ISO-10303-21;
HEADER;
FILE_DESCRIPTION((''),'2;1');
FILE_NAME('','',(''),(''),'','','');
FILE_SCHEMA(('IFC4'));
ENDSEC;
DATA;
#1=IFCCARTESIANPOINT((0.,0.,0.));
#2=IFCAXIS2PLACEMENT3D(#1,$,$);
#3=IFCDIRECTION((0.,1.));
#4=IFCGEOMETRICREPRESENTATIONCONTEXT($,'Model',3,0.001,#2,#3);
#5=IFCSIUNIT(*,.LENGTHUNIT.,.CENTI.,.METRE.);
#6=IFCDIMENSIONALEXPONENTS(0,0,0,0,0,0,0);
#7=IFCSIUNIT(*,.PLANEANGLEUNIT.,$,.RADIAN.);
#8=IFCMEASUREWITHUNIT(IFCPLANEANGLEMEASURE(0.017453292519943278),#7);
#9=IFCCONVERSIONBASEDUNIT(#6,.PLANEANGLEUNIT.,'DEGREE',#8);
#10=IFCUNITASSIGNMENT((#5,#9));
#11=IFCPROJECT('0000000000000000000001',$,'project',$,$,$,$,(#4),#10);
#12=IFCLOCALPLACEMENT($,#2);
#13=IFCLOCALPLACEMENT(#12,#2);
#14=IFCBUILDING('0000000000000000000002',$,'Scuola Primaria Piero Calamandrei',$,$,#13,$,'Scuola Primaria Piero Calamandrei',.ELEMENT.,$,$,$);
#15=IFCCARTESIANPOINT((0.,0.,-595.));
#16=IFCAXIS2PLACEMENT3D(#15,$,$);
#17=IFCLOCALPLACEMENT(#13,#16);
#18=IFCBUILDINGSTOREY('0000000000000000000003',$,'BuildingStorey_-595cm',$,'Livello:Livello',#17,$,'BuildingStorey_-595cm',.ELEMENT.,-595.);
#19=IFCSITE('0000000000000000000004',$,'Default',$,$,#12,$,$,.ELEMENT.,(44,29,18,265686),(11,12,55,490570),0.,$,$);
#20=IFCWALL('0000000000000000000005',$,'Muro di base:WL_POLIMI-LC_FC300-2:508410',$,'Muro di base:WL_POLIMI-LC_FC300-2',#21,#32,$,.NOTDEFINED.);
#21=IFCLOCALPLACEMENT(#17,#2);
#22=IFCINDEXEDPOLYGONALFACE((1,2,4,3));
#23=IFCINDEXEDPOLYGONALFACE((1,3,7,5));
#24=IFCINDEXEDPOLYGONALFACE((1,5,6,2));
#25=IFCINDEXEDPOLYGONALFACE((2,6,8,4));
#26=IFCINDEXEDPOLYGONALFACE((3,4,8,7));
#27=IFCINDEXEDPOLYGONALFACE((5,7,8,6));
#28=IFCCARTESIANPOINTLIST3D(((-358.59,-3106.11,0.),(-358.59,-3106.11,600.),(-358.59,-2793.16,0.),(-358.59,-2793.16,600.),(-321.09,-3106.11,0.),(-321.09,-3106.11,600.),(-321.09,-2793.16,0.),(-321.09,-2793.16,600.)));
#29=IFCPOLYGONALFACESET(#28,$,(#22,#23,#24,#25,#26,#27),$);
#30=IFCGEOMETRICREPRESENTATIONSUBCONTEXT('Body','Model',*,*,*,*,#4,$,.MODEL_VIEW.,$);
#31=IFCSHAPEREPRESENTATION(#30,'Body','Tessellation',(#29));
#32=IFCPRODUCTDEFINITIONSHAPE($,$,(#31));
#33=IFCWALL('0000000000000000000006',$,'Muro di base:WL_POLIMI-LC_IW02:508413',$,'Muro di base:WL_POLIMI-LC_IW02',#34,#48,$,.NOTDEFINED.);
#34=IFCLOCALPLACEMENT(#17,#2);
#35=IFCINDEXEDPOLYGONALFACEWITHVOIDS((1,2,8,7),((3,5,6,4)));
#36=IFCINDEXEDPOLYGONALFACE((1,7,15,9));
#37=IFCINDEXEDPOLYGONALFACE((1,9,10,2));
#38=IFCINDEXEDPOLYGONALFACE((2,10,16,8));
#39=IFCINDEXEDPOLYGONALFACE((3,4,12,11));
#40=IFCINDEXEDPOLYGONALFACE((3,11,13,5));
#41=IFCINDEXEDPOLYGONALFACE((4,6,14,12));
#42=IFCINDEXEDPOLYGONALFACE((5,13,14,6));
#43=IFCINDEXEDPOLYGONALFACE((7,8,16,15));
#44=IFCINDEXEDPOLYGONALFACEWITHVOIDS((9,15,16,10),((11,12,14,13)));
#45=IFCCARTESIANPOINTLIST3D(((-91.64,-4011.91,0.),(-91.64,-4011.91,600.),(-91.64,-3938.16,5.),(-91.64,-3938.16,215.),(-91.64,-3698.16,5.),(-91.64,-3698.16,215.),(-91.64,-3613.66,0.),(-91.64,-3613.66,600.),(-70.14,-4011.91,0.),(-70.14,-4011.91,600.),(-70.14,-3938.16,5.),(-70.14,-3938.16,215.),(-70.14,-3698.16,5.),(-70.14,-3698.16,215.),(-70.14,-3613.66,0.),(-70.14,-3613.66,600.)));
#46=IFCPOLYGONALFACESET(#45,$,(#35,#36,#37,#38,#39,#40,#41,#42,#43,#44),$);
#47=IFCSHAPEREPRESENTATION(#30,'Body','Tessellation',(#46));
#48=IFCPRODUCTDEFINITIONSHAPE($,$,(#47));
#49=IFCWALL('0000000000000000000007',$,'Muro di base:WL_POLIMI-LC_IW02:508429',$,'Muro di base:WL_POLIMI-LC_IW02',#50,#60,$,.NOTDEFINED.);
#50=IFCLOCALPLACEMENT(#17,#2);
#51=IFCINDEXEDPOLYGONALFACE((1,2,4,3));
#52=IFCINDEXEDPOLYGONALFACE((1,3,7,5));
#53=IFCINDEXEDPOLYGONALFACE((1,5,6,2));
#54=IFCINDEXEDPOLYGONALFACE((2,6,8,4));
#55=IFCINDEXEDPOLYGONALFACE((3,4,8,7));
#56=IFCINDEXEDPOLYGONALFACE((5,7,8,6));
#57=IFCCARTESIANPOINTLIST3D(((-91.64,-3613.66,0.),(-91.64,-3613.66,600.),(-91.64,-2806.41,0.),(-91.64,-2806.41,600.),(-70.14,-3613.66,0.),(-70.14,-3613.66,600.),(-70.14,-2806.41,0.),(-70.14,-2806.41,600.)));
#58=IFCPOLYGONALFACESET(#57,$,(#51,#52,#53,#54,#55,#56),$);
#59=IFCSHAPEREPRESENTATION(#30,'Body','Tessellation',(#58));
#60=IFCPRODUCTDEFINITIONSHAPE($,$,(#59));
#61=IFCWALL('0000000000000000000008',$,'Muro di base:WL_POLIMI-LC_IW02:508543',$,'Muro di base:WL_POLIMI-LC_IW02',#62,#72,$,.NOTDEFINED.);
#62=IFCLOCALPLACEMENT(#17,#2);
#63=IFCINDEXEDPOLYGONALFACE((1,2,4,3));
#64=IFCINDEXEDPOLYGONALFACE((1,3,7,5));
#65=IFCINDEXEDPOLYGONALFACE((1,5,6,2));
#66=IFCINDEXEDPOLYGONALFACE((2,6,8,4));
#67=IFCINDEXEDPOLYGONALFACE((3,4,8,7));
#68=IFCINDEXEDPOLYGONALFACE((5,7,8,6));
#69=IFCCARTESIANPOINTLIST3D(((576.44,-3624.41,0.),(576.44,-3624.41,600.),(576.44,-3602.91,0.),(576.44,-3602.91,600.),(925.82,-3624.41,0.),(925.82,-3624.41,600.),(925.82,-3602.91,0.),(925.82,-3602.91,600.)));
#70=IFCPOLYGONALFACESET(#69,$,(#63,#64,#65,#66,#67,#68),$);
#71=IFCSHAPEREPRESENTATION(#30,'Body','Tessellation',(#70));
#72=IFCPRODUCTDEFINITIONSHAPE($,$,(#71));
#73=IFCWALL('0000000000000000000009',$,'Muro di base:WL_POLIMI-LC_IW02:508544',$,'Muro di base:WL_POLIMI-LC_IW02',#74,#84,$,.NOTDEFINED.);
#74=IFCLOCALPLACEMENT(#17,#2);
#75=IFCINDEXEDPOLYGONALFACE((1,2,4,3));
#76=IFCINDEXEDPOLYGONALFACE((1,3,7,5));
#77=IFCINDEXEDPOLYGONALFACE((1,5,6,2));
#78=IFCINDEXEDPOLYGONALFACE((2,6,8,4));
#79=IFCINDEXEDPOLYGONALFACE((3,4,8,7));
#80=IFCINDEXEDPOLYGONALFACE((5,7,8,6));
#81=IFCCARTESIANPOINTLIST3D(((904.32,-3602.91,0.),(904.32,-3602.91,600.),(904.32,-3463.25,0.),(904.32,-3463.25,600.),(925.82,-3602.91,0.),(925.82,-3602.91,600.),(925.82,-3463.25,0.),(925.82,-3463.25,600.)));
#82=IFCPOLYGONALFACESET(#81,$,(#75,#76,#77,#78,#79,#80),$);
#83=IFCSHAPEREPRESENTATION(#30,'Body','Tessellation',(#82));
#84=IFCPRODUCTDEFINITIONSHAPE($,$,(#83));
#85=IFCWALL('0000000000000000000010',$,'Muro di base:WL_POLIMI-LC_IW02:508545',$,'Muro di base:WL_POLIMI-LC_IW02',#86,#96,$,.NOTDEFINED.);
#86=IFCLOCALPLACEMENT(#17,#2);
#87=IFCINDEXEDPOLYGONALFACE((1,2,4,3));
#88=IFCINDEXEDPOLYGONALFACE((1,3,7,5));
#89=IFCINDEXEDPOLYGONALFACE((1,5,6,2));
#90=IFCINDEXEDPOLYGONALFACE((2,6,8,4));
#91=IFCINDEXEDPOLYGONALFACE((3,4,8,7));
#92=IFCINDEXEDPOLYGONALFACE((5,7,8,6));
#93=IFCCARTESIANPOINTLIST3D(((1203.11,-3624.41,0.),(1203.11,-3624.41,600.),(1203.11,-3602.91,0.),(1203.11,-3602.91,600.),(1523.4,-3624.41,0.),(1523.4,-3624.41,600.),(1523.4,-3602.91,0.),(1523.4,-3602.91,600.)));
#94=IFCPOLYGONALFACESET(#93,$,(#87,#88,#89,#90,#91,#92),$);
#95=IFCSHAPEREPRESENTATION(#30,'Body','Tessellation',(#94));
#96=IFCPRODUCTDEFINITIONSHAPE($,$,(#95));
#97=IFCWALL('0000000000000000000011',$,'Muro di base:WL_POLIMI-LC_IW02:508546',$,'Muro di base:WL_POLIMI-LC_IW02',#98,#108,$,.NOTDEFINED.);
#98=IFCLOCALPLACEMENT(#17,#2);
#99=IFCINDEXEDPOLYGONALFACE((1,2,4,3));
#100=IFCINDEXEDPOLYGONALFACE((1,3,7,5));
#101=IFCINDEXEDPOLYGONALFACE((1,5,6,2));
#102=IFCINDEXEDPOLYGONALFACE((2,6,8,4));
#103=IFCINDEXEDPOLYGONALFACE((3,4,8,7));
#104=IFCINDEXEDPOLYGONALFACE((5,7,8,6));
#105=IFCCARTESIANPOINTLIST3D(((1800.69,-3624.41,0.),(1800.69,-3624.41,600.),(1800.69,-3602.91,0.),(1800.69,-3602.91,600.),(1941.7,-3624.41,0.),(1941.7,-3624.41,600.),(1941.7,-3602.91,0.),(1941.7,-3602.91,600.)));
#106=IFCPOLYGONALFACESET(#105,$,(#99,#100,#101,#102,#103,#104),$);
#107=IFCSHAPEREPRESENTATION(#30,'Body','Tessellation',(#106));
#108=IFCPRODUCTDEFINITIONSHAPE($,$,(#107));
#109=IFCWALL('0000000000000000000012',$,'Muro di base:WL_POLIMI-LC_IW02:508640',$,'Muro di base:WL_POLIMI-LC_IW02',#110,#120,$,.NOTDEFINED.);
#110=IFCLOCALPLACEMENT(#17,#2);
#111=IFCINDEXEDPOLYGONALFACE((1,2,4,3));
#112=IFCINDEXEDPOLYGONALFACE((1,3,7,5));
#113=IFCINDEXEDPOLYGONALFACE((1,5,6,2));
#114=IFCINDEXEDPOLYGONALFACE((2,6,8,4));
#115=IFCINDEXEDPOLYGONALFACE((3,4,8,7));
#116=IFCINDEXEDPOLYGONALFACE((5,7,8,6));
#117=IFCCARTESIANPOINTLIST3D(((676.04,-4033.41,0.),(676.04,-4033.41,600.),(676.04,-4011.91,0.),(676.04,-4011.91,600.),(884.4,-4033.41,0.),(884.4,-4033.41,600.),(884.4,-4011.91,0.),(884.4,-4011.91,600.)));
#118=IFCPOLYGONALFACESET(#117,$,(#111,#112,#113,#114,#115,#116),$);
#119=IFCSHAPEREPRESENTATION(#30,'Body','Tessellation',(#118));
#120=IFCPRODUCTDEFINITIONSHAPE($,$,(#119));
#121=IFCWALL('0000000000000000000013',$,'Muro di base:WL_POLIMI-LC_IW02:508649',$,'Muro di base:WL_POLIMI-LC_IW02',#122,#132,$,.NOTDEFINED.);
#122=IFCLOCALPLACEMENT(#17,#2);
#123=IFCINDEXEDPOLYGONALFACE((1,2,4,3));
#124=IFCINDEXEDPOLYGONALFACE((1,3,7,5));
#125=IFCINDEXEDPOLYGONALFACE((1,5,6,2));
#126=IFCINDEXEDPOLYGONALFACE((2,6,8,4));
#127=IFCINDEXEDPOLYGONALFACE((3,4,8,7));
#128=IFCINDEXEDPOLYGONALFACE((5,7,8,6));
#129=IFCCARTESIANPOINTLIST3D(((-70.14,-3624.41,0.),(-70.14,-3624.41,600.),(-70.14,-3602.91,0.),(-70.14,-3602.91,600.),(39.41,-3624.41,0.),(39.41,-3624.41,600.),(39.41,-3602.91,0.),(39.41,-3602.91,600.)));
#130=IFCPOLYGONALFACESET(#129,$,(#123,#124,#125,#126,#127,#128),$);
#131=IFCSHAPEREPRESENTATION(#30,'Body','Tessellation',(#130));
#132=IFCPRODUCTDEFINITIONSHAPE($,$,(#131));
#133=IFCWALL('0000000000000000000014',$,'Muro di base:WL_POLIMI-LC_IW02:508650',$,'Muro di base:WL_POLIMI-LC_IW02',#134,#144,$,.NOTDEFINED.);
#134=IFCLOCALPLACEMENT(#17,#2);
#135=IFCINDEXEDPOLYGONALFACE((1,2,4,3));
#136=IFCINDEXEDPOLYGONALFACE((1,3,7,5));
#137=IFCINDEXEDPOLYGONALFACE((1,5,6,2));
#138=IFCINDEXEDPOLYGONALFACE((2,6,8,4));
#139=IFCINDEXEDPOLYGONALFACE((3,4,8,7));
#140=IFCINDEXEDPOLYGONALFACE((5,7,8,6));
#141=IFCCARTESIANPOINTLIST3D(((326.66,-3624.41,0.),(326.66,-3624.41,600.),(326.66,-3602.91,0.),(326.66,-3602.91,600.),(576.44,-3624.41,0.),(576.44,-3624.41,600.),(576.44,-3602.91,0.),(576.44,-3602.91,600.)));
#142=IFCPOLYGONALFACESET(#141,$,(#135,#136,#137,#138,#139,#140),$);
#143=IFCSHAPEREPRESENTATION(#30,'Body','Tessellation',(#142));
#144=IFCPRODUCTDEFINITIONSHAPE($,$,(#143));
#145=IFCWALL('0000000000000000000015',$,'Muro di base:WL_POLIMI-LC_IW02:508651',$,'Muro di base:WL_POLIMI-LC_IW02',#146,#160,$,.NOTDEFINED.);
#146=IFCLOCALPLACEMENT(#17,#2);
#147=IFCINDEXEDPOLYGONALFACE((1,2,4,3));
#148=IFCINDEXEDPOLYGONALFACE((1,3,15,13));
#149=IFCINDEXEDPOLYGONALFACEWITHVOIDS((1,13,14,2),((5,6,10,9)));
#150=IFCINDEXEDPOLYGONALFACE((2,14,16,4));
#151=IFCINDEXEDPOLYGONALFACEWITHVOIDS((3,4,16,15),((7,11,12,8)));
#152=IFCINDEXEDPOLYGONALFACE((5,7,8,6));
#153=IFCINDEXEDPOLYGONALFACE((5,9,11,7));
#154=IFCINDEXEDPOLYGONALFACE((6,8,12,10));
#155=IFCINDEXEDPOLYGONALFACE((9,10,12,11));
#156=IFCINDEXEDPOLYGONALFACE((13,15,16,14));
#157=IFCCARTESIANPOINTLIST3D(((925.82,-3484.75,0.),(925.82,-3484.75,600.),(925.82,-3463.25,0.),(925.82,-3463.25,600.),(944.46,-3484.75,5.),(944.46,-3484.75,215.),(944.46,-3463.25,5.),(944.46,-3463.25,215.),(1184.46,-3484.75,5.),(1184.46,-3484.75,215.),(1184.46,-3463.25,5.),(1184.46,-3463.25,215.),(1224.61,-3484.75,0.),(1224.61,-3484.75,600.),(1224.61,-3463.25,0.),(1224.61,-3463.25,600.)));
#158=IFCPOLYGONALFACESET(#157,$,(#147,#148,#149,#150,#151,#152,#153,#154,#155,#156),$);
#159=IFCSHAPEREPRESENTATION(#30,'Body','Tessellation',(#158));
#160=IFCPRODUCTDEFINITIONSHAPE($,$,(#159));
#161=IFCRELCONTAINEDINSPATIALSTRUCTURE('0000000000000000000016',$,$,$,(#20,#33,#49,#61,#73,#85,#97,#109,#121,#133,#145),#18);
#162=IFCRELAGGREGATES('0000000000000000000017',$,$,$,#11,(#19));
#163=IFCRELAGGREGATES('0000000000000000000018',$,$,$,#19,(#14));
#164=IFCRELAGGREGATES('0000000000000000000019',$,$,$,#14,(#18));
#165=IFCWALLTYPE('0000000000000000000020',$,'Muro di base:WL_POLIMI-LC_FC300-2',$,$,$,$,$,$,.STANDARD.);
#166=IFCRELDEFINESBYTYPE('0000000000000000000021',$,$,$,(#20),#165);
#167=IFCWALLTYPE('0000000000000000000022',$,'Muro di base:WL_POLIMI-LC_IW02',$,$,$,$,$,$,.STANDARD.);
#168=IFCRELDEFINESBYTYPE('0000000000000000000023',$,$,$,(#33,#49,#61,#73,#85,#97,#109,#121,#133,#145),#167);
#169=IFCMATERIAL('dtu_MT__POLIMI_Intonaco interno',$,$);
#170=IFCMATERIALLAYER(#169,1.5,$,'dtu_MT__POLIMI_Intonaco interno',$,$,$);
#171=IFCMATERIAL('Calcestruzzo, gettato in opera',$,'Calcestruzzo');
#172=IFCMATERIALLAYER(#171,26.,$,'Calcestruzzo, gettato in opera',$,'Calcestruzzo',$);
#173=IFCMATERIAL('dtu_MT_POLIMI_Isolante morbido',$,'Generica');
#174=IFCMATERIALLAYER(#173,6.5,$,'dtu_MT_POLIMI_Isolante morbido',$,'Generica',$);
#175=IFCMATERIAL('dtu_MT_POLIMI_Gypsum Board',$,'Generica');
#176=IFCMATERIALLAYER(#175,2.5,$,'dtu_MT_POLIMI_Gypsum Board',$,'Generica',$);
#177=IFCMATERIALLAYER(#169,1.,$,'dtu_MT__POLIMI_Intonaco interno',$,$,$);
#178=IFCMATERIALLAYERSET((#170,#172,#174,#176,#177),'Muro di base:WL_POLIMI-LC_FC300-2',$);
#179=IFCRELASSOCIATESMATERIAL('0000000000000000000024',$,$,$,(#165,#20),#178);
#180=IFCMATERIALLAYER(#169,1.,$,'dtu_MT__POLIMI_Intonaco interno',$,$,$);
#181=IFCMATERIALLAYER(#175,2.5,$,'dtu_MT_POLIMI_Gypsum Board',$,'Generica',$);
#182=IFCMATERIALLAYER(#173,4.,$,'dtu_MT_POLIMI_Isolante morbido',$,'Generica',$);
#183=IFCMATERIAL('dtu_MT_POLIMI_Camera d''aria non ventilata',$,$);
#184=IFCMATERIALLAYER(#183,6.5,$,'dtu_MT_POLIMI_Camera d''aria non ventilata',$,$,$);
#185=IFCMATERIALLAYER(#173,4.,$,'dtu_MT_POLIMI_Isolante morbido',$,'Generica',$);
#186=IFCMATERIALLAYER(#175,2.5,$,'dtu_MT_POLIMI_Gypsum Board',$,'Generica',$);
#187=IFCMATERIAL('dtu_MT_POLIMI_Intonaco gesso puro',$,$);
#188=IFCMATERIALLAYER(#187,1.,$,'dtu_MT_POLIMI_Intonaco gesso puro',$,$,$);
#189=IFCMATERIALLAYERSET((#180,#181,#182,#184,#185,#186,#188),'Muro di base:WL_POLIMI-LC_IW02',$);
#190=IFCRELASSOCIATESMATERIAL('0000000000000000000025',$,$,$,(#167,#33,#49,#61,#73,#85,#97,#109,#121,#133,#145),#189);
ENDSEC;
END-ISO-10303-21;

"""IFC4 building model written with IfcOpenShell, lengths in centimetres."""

from ifc_helpers import new_model, entity, si_unit, converted_unit, direction, frame, frame_2d, origin, place, context, subcontext, project, spatial, rectangle, extrude, material, layer, layer_set, layer_usage, type_object, element, save


model = new_model("IFC4")

# Units and contexts
model_context = context("Model", 3, precision=0.001, world=origin(), true_north=direction((0.0, 1.0)))
body_context = subcontext(model_context, "Body", "Model", "MODEL_VIEW")
ifc_project = project(units=[si_unit("LENGTHUNIT", "METRE", prefix="CENTI"), converted_unit("PLANEANGLEUNIT", "DEGREE", entity("IfcPlaneAngleMeasure", 0.017453292519943278), si_unit("PLANEANGLEUNIT", "RADIAN"), dimensions=[0, 0, 0, 0, 0, 0, 0])], contexts=[model_context])

# Site, building, storey
site_placement = place(None, origin())
site = spatial("IfcSite", under=ifc_project, at=site_placement, Name="Default", CompositionType="ELEMENT", RefLatitude=(44, 29, 18, 265686), RefLongitude=(11, 12, 55, 490570), RefElevation=0.0)
building_placement = place(site_placement, origin())
building = spatial("IfcBuilding", under=site, at=building_placement, Name="Scuola Primaria Piero Calamandrei", LongName="Scuola Primaria Piero Calamandrei", CompositionType="ELEMENT")
storey_placement = place(building_placement, frame((0.0, 0.0, -595.0)))
storey = spatial("IfcBuildingStorey", under=building, at=storey_placement, Name="BuildingStorey_-595cm", ObjectType="Livello:Livello", LongName="BuildingStorey_-595cm", CompositionType="ELEMENT", Elevation=-595.0)

# Wall
ifc_material_1 = material(Name="dtu_MT__POLIMI_Intonaco interno")
ifc_layer_1 = layer(ifc_material_1, 1.5, Name="dtu_MT__POLIMI_Intonaco interno")
ifc_material_2 = material(Name="Calcestruzzo, gettato in opera", Category="Calcestruzzo")
ifc_layer_2 = layer(ifc_material_2, 26.0, Name="Calcestruzzo, gettato in opera", Category="Calcestruzzo")
ifc_material_3 = material(Name="dtu_MT_POLIMI_Isolante morbido", Category="Generica")
ifc_layer_3 = layer(ifc_material_3, 6.5, Name="dtu_MT_POLIMI_Isolante morbido", Category="Generica")
ifc_material_4 = material(Name="dtu_MT_POLIMI_Gypsum Board", Category="Generica")
ifc_layer_4 = layer(ifc_material_4, 2.5, Name="dtu_MT_POLIMI_Gypsum Board", Category="Generica")
ifc_layer_5 = layer(ifc_material_1, 1.0, Name="dtu_MT__POLIMI_Intonaco interno")
ifc_layer_set_1 = layer_set([ifc_layer_1, ifc_layer_2, ifc_layer_3, ifc_layer_4, ifc_layer_5], Name="Muro di base:WL_POLIMI-LC_FC300-2")
ifc_layer_usage_1 = layer_usage(ifc_layer_set_1, "AXIS2", "NEGATIVE", 18.75)
wall_type_1 = type_object("IfcWallType", Name="Muro di base:WL_POLIMI-LC_FC300-2", PredefinedType="STANDARD", material=ifc_layer_set_1)
wall_1_placement = place(storey_placement, frame((-339.84, -3106.11, 0.0), z_axis=(0.0, 0.0, 1.0), x_axis=(0.0, 1.0, 0.0)))
element("IfcWall", 1, at=wall_1_placement, inside=storey, type_object=wall_type_1, material=ifc_layer_usage_1, Name="Muro di base:WL_POLIMI-LC_FC300-2:508410", ObjectType="Muro di base:WL_POLIMI-LC_FC300-2", PredefinedType="NOTDEFINED", context=body_context, shape_type="SweptSolid", body=[
    extrude(rectangle(XDim=312.94, YDim=37.5, at=frame_2d((156.47, 0.0), x_axis=(-1.0, 0.0))), origin(), (0.0, 0.0, 1.0), 600.0),
])

# Wall, opening
ifc_layer_6 = layer(ifc_material_1, 1.0, Name="dtu_MT__POLIMI_Intonaco interno")
ifc_layer_7 = layer(ifc_material_4, 2.5, Name="dtu_MT_POLIMI_Gypsum Board", Category="Generica")
ifc_layer_8 = layer(ifc_material_3, 4.0, Name="dtu_MT_POLIMI_Isolante morbido", Category="Generica")
ifc_material_5 = material(Name="dtu_MT_POLIMI_Camera d'aria non ventilata")
ifc_layer_9 = layer(ifc_material_5, 6.5, Name="dtu_MT_POLIMI_Camera d'aria non ventilata")
ifc_layer_10 = layer(ifc_material_3, 4.0, Name="dtu_MT_POLIMI_Isolante morbido", Category="Generica")
ifc_layer_11 = layer(ifc_material_4, 2.5, Name="dtu_MT_POLIMI_Gypsum Board", Category="Generica")
ifc_material_6 = material(Name="dtu_MT_POLIMI_Intonaco gesso puro")
ifc_layer_12 = layer(ifc_material_6, 1.0, Name="dtu_MT_POLIMI_Intonaco gesso puro")
ifc_layer_set_2 = layer_set([ifc_layer_6, ifc_layer_7, ifc_layer_8, ifc_layer_9, ifc_layer_10, ifc_layer_11, ifc_layer_12], Name="Muro di base:WL_POLIMI-LC_IW02")
ifc_layer_usage_2 = layer_usage(ifc_layer_set_2, "AXIS2", "NEGATIVE", 10.75)
wall_type_2 = type_object("IfcWallType", Name="Muro di base:WL_POLIMI-LC_IW02", PredefinedType="STANDARD", material=ifc_layer_set_2)
wall_2_placement = place(storey_placement, frame((-80.89, -3613.66, 0.0), z_axis=(0.0, 0.0, 1.0), x_axis=(0.0, -1.0, 0.0)))
wall_2 = element("IfcWall", 2, at=wall_2_placement, inside=storey, type_object=wall_type_2, material=ifc_layer_usage_2, Name="Muro di base:WL_POLIMI-LC_IW02:508413", ObjectType="Muro di base:WL_POLIMI-LC_IW02", PredefinedType="NOTDEFINED", context=body_context, shape_type="SweptSolid", body=[
    extrude(rectangle(XDim=398.25, YDim=21.5, at=frame_2d((199.12, 0.0), x_axis=(-1.0, 0.0))), origin(), (0.0, 0.0, 1.0), 600.0),
])
opening_1_placement = place(wall_2_placement, frame((324.5, 10.75, 5.0)))
element("IfcOpeningElement", 3, at=opening_1_placement, cuts=wall_2, PredefinedType="OPENING", context=body_context, shape_type="SweptSolid", body=[
    extrude(rectangle(XDim=210.0, YDim=240.0, at=frame_2d((105.0, 120.0), x_axis=(-1.0, 0.0))), frame((0.0, 0.0, 0.0), z_axis=(0.0, -1.0, 0.0), x_axis=(0.0, 0.0, 1.0)), (0.0, 0.0, 1.0), 21.5),
])

# Walls
ifc_layer_usage_3 = layer_usage(ifc_layer_set_2, "AXIS2", "NEGATIVE", 10.75)
wall_3_placement = place(storey_placement, frame((-80.89, -2806.41, 0.0), z_axis=(0.0, 0.0, 1.0), x_axis=(0.0, -1.0, 0.0)))
element("IfcWall", 4, at=wall_3_placement, inside=storey, type_object=wall_type_2, material=ifc_layer_usage_3, Name="Muro di base:WL_POLIMI-LC_IW02:508429", ObjectType="Muro di base:WL_POLIMI-LC_IW02", PredefinedType="NOTDEFINED", context=body_context, shape_type="SweptSolid", body=[
    extrude(rectangle(XDim=807.25, YDim=21.5, at=frame_2d((403.62, 0.0), x_axis=(-1.0, 0.0))), origin(), (0.0, 0.0, 1.0), 600.0),
])
ifc_layer_usage_4 = layer_usage(ifc_layer_set_2, "AXIS2", "NEGATIVE", 10.75)
wall_4_placement = place(storey_placement, frame((576.44, -3613.66, 0.0)))
element("IfcWall", 5, at=wall_4_placement, inside=storey, type_object=wall_type_2, material=ifc_layer_usage_4, Name="Muro di base:WL_POLIMI-LC_IW02:508543", ObjectType="Muro di base:WL_POLIMI-LC_IW02", PredefinedType="NOTDEFINED", context=body_context, shape_type="SweptSolid", body=[
    extrude(rectangle(XDim=349.38, YDim=21.5, at=frame_2d((174.69, 0.0), x_axis=(-1.0, 0.0))), origin(), (0.0, 0.0, 1.0), 600.0),
])
ifc_layer_usage_5 = layer_usage(ifc_layer_set_2, "AXIS2", "NEGATIVE", 10.75)
wall_5_placement = place(storey_placement, frame((915.07, -3602.91, 0.0), z_axis=(0.0, 0.0, 1.0), x_axis=(0.0, 1.0, 0.0)))
element("IfcWall", 6, at=wall_5_placement, inside=storey, type_object=wall_type_2, material=ifc_layer_usage_5, Name="Muro di base:WL_POLIMI-LC_IW02:508544", ObjectType="Muro di base:WL_POLIMI-LC_IW02", PredefinedType="NOTDEFINED", context=body_context, shape_type="SweptSolid", body=[
    extrude(rectangle(XDim=139.66, YDim=21.5, at=frame_2d((69.83, 0.0), x_axis=(-1.0, 0.0))), origin(), (0.0, 0.0, 1.0), 600.0),
])
ifc_layer_usage_6 = layer_usage(ifc_layer_set_2, "AXIS2", "NEGATIVE", 10.75)
wall_6_placement = place(storey_placement, frame((1203.11, -3613.66, 0.0)))
element("IfcWall", 7, at=wall_6_placement, inside=storey, type_object=wall_type_2, material=ifc_layer_usage_6, Name="Muro di base:WL_POLIMI-LC_IW02:508545", ObjectType="Muro di base:WL_POLIMI-LC_IW02", PredefinedType="NOTDEFINED", context=body_context, shape_type="SweptSolid", body=[
    extrude(rectangle(XDim=320.29, YDim=21.5, at=frame_2d((160.14, 0.0), x_axis=(-1.0, 0.0))), origin(), (0.0, 0.0, 1.0), 600.0),
])
ifc_layer_usage_7 = layer_usage(ifc_layer_set_2, "AXIS2", "NEGATIVE", 10.75)
wall_7_placement = place(storey_placement, frame((1800.69, -3613.66, 0.0)))
element("IfcWall", 8, at=wall_7_placement, inside=storey, type_object=wall_type_2, material=ifc_layer_usage_7, Name="Muro di base:WL_POLIMI-LC_IW02:508546", ObjectType="Muro di base:WL_POLIMI-LC_IW02", PredefinedType="NOTDEFINED", context=body_context, shape_type="SweptSolid", body=[
    extrude(rectangle(XDim=141.02, YDim=21.5, at=frame_2d((70.51, 0.0), x_axis=(-1.0, 0.0))), origin(), (0.0, 0.0, 1.0), 600.0),
])
ifc_layer_usage_8 = layer_usage(ifc_layer_set_2, "AXIS2", "NEGATIVE", 10.75)
wall_8_placement = place(storey_placement, frame((884.4, -4022.66, 0.0), z_axis=(0.0, 0.0, 1.0), x_axis=(-1.0, 0.0, 0.0)))
element("IfcWall", 9, at=wall_8_placement, inside=storey, type_object=wall_type_2, material=ifc_layer_usage_8, Name="Muro di base:WL_POLIMI-LC_IW02:508640", ObjectType="Muro di base:WL_POLIMI-LC_IW02", PredefinedType="NOTDEFINED", context=body_context, shape_type="SweptSolid", body=[
    extrude(rectangle(XDim=208.36, YDim=21.5, at=frame_2d((104.18, 0.0), x_axis=(-1.0, 0.0))), origin(), (0.0, 0.0, 1.0), 600.0),
])
ifc_layer_usage_9 = layer_usage(ifc_layer_set_2, "AXIS2", "NEGATIVE", 10.75)
wall_9_placement = place(storey_placement, frame((-70.14, -3613.66, 0.0)))
element("IfcWall", 10, at=wall_9_placement, inside=storey, type_object=wall_type_2, material=ifc_layer_usage_9, Name="Muro di base:WL_POLIMI-LC_IW02:508649", ObjectType="Muro di base:WL_POLIMI-LC_IW02", PredefinedType="NOTDEFINED", context=body_context, shape_type="SweptSolid", body=[
    extrude(rectangle(XDim=109.56, YDim=21.5, at=frame_2d((54.78, 0.0), x_axis=(-1.0, 0.0))), origin(), (0.0, 0.0, 1.0), 600.0),
])
ifc_layer_usage_10 = layer_usage(ifc_layer_set_2, "AXIS2", "NEGATIVE", 10.75)
wall_10_placement = place(storey_placement, frame((326.66, -3613.66, 0.0)))
element("IfcWall", 11, at=wall_10_placement, inside=storey, type_object=wall_type_2, material=ifc_layer_usage_10, Name="Muro di base:WL_POLIMI-LC_IW02:508650", ObjectType="Muro di base:WL_POLIMI-LC_IW02", PredefinedType="NOTDEFINED", context=body_context, shape_type="SweptSolid", body=[
    extrude(rectangle(XDim=249.78, YDim=21.5, at=frame_2d((124.89, 0.0), x_axis=(-1.0, 0.0))), origin(), (0.0, 0.0, 1.0), 600.0),
])

# Wall, opening
ifc_layer_usage_11 = layer_usage(ifc_layer_set_2, "AXIS2", "NEGATIVE", 10.75)
wall_11_placement = place(storey_placement, frame((925.82, -3474.0, 0.0)))
wall_11 = element("IfcWall", 12, at=wall_11_placement, inside=storey, type_object=wall_type_2, material=ifc_layer_usage_11, Name="Muro di base:WL_POLIMI-LC_IW02:508651", ObjectType="Muro di base:WL_POLIMI-LC_IW02", PredefinedType="NOTDEFINED", context=body_context, shape_type="SweptSolid", body=[
    extrude(rectangle(XDim=298.79, YDim=21.5, at=frame_2d((149.39, 0.0), x_axis=(-1.0, 0.0))), origin(), (0.0, 0.0, 1.0), 600.0),
])
opening_2_placement = place(wall_11_placement, frame((258.64, 10.75, 5.0)))
element("IfcOpeningElement", 13, at=opening_2_placement, cuts=wall_11, PredefinedType="OPENING", context=body_context, shape_type="SweptSolid", body=[
    extrude(rectangle(XDim=210.0, YDim=240.0, at=frame_2d((105.0, 120.0), x_axis=(-1.0, 0.0))), frame((0.0, 0.0, 0.0), z_axis=(0.0, -1.0, 0.0), x_axis=(0.0, 0.0, 1.0)), (0.0, 0.0, 1.0), 21.5),
])

save(model, "model.ifc")
